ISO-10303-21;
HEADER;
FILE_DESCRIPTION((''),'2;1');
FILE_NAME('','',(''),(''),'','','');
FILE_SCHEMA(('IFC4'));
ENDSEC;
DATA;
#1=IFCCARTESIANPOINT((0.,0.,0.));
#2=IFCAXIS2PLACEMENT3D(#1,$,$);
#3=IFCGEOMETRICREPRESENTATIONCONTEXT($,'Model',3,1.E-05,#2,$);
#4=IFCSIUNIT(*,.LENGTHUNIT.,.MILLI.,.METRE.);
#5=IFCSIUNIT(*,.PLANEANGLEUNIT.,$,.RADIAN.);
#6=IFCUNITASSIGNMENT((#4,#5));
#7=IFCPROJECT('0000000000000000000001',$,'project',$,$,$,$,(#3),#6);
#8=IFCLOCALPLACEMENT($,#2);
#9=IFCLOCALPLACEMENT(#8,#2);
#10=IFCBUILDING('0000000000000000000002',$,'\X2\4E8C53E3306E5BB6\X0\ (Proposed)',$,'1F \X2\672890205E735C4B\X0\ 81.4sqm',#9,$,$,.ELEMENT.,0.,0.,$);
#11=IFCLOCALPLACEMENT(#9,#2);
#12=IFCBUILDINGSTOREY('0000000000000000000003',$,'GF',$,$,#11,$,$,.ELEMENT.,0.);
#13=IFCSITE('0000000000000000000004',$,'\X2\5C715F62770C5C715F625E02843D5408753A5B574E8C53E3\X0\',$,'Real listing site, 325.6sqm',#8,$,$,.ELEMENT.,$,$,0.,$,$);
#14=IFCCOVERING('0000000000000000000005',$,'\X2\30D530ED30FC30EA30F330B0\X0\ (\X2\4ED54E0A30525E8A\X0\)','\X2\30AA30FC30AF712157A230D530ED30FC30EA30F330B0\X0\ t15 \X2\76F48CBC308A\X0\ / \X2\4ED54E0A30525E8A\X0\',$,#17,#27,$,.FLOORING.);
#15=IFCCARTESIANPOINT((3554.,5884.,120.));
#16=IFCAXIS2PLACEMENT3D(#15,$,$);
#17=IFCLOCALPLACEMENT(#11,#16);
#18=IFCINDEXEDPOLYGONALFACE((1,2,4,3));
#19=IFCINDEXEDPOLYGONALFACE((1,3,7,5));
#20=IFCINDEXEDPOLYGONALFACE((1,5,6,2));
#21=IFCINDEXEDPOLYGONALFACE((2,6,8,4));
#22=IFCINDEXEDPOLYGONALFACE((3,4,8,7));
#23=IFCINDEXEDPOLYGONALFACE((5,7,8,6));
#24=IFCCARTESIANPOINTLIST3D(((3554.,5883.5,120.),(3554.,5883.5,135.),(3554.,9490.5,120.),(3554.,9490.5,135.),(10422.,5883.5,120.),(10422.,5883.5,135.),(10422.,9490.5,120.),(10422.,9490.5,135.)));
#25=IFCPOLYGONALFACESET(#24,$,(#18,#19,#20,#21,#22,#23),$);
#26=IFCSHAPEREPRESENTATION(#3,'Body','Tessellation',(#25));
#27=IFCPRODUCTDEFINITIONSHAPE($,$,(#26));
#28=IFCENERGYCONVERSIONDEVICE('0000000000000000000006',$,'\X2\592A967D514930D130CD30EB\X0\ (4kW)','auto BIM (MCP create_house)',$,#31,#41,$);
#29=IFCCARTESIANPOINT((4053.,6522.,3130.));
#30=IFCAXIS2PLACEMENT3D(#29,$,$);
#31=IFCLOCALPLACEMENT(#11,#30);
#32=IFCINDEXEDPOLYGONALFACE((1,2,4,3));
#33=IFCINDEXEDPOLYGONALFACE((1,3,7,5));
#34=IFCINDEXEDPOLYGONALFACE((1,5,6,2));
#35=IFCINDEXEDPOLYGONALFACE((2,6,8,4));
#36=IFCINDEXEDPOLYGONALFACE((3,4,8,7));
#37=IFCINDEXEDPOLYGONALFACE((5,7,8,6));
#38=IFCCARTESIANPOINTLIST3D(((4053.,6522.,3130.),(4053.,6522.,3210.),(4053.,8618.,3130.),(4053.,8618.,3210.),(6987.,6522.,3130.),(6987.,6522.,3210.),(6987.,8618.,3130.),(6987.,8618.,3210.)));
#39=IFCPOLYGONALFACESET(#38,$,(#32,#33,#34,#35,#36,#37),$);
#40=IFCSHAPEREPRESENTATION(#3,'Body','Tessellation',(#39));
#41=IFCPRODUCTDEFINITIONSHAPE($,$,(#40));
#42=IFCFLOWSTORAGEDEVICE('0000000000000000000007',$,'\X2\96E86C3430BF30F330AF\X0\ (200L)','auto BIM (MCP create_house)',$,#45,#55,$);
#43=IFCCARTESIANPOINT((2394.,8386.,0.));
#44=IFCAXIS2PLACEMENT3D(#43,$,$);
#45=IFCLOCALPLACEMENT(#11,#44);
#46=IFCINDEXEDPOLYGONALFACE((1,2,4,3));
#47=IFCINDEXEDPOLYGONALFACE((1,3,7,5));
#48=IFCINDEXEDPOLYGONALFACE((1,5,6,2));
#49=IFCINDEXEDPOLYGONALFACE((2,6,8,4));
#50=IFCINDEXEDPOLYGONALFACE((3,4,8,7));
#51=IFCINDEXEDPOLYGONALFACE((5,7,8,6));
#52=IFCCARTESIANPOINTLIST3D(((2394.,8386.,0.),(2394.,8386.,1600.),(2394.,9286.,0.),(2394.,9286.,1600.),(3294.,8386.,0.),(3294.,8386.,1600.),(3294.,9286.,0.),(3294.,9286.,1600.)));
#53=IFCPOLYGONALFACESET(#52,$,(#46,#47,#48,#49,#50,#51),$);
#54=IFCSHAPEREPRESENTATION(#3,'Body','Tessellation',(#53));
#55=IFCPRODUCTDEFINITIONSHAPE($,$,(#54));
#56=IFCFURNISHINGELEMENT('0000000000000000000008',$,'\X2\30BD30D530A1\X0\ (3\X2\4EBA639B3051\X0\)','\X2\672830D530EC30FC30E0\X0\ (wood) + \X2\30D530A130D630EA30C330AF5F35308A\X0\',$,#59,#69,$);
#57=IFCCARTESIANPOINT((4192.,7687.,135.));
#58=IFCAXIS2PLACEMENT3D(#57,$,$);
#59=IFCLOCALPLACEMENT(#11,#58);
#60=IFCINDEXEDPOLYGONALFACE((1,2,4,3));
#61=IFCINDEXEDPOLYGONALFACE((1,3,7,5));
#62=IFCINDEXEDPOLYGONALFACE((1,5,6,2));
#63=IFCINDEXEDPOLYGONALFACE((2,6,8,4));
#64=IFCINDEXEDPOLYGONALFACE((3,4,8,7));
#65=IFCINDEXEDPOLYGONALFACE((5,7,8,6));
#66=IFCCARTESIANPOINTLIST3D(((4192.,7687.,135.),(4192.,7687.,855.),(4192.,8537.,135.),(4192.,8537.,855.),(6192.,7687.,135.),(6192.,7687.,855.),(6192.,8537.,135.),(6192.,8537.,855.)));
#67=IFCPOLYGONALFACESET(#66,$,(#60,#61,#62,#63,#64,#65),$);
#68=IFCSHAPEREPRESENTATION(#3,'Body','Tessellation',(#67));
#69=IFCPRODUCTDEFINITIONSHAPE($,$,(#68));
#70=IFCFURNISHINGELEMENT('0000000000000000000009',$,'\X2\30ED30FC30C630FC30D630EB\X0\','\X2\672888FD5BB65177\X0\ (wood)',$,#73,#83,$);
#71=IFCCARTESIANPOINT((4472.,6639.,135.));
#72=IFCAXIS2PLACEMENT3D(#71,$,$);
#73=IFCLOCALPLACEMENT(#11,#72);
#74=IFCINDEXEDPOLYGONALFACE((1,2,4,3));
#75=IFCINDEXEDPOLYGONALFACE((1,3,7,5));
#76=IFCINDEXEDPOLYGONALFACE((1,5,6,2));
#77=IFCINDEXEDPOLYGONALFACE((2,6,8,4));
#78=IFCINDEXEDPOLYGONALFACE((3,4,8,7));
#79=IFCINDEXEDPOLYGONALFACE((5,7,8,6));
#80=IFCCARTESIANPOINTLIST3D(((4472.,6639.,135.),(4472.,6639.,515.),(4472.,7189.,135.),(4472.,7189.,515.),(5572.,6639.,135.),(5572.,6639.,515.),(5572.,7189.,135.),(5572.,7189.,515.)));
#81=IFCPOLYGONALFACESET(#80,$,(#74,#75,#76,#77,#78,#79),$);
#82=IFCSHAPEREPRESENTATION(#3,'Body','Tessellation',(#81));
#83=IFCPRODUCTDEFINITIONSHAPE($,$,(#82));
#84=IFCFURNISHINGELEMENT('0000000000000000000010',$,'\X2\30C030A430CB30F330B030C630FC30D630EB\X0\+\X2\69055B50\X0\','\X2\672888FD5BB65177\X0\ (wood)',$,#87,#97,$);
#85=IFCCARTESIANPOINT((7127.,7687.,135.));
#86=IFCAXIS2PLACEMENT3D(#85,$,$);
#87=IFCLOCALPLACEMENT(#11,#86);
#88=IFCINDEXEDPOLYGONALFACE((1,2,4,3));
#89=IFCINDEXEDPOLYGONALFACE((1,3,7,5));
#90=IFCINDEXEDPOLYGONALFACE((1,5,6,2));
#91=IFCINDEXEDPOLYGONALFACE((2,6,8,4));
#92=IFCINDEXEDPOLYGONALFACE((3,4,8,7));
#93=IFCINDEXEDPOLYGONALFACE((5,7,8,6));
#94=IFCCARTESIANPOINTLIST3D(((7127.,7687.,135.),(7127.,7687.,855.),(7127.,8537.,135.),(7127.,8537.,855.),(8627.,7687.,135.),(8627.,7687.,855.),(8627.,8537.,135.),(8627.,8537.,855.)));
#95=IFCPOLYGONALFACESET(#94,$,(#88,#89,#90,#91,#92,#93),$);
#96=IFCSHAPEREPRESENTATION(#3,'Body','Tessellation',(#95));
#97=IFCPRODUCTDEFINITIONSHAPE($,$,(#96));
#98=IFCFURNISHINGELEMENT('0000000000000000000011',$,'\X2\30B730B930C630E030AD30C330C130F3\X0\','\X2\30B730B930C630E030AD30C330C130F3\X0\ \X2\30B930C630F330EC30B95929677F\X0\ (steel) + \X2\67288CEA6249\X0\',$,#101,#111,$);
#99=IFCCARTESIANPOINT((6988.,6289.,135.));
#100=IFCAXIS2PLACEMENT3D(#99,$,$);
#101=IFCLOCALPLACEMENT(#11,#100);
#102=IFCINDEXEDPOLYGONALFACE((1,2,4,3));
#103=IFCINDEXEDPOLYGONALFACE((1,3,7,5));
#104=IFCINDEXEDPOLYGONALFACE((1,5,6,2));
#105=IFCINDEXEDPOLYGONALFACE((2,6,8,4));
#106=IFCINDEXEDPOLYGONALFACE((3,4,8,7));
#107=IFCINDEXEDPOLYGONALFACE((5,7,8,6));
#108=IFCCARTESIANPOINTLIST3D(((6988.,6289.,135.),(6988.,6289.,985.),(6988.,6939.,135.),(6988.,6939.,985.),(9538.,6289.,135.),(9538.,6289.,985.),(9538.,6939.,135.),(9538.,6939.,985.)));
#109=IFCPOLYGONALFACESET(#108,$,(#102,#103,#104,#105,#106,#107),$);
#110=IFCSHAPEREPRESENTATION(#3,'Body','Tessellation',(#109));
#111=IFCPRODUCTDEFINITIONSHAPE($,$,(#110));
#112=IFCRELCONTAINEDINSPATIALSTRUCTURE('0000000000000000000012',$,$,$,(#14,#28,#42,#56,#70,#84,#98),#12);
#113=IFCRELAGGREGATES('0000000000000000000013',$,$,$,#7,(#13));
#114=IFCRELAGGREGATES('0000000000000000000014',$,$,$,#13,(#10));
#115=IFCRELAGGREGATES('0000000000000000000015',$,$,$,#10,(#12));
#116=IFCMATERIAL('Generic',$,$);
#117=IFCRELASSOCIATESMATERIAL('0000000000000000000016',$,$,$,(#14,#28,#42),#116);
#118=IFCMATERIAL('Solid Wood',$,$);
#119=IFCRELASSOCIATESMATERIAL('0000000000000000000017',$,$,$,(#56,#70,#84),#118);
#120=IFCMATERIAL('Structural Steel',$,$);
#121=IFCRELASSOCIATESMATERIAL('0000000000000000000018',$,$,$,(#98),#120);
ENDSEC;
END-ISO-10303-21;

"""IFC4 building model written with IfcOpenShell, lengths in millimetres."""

from ifc_helpers import new_model, si_unit, frame, frame_2d, origin, place, context, project, spatial, rectangle, extrude, material, element, save


model = new_model("IFC4")

# Units and contexts
model_context = context("Model", 3, precision=1e-05, world=origin())
ifc_project = project(units=[si_unit("LENGTHUNIT", "METRE", prefix="MILLI"), si_unit("PLANEANGLEUNIT", "RADIAN")], contexts=[model_context])

# Site, building, storey
site_placement = place(None, origin())
site = spatial("IfcSite", under=ifc_project, at=site_placement, Name="山形県山形市落合町字二口", ObjectType="Real listing site, 325.6sqm", CompositionType="ELEMENT", RefElevation=0.0)
building_placement = place(site_placement, origin())
building = spatial("IfcBuilding", under=site, at=building_placement, Name="二口の家 (Proposed)", ObjectType="1F 木造平屋 81.4sqm", CompositionType="ELEMENT", ElevationOfRefHeight=0.0, ElevationOfTerrain=0.0)
storey_placement = place(building_placement, origin())
storey = spatial("IfcBuildingStorey", under=building, at=storey_placement, Name="GF", CompositionType="ELEMENT", Elevation=0.0)

# Shared definitions
ifc_material_1 = material(Name="Solid Wood")

# Shared definitions
ifc_material_2 = material(Name="Structural Steel")

# Covering
ifc_material_3 = material(Name="Generic")
covering_placement = place(storey_placement, frame((3554.0, 5884.0, 120.0)))
element("IfcCovering", 1, at=covering_placement, inside=storey, material=ifc_material_3, Name="フローリング (仕上げ床)", Description="オーク無垢フローリング t15 直貼り / 仕上げ床", PredefinedType="FLOORING", context=model_context, shape_type="SweptSolid", body=[
    extrude(rectangle(XDim=6868.0, YDim=3607.0, at=frame_2d((3434.0, 1803.0))), frame((3554.0, 5884.0, 120.0)), (0.0, 0.0, 1.0), 15.0),
])

# Energy conversion device
energy_conversion_device_placement = place(storey_placement, frame((4053.0, 6522.0, 3130.0)))
element("IfcEnergyConversionDevice", 2, at=energy_conversion_device_placement, inside=storey, material=ifc_material_3, Name="太陽光パネル (4kW)", Description="auto BIM (MCP create_house)", context=model_context, shape_type="SweptSolid", body=[
    extrude(rectangle(XDim=2934.0, YDim=2096.0, at=frame_2d((1467.0, 1048.0))), frame((4053.0, 6522.0, 3130.0)), (0.0, 0.0, 1.0), 80.0),
])

# Flow storage device
flow_storage_device_placement = place(storey_placement, frame((2394.0, 8386.0, 0.0)))
element("IfcFlowStorageDevice", 3, at=flow_storage_device_placement, inside=storey, material=ifc_material_3, Name="雨水タンク (200L)", Description="auto BIM (MCP create_house)", context=model_context, shape_type="SweptSolid", body=[
    extrude(rectangle(XDim=900.0, YDim=900.0, at=frame_2d((450.0, 450.0))), frame((2394.0, 8386.0, 0.0)), (0.0, 0.0, 1.0), 1600.0),
])

# Furnishing elements
furnishing_1_placement = place(storey_placement, frame((4192.0, 7687.0, 135.0)))
element("IfcFurnishingElement", 4, at=furnishing_1_placement, inside=storey, material=ifc_material_1, Name="ソファ (3人掛け)", Description="木フレーム (wood) + ファブリック張り", context=model_context, shape_type="SweptSolid", body=[
    extrude(rectangle(XDim=2000.0, YDim=850.0, at=frame_2d((1000.0, 425.0))), frame((4192.0, 7687.0, 135.0)), (0.0, 0.0, 1.0), 720.0),
])
furnishing_2_placement = place(storey_placement, frame((4472.0, 6639.0, 135.0)))
element("IfcFurnishingElement", 5, at=furnishing_2_placement, inside=storey, material=ifc_material_1, Name="ローテーブル", Description="木製家具 (wood)", context=model_context, shape_type="SweptSolid", body=[
    extrude(rectangle(XDim=1100.0, YDim=550.0, at=frame_2d((550.0, 275.0))), frame((4472.0, 6639.0, 135.0)), (0.0, 0.0, 1.0), 380.0),
])
furnishing_3_placement = place(storey_placement, frame((7127.0, 7687.0, 135.0)))
element("IfcFurnishingElement", 6, at=furnishing_3_placement, inside=storey, material=ifc_material_1, Name="ダイニングテーブル+椅子", Description="木製家具 (wood)", context=model_context, shape_type="SweptSolid", body=[
    extrude(rectangle(XDim=1500.0, YDim=850.0, at=frame_2d((750.0, 425.0))), frame((7127.0, 7687.0, 135.0)), (0.0, 0.0, 1.0), 720.0),
])
furnishing_4_placement = place(storey_placement, frame((6988.0, 6289.0, 135.0)))
element("IfcFurnishingElement", 7, at=furnishing_4_placement, inside=storey, material=ifc_material_2, Name="システムキッチン", Description="システムキッチン ステンレス天板 (steel) + 木質扉", context=model_context, shape_type="SweptSolid", body=[
    extrude(rectangle(XDim=2550.0, YDim=650.0, at=frame_2d((1275.0, 325.0))), frame((6988.0, 6289.0, 135.0)), (0.0, 0.0, 1.0), 850.0),
])

save(model, "model.ifc")
